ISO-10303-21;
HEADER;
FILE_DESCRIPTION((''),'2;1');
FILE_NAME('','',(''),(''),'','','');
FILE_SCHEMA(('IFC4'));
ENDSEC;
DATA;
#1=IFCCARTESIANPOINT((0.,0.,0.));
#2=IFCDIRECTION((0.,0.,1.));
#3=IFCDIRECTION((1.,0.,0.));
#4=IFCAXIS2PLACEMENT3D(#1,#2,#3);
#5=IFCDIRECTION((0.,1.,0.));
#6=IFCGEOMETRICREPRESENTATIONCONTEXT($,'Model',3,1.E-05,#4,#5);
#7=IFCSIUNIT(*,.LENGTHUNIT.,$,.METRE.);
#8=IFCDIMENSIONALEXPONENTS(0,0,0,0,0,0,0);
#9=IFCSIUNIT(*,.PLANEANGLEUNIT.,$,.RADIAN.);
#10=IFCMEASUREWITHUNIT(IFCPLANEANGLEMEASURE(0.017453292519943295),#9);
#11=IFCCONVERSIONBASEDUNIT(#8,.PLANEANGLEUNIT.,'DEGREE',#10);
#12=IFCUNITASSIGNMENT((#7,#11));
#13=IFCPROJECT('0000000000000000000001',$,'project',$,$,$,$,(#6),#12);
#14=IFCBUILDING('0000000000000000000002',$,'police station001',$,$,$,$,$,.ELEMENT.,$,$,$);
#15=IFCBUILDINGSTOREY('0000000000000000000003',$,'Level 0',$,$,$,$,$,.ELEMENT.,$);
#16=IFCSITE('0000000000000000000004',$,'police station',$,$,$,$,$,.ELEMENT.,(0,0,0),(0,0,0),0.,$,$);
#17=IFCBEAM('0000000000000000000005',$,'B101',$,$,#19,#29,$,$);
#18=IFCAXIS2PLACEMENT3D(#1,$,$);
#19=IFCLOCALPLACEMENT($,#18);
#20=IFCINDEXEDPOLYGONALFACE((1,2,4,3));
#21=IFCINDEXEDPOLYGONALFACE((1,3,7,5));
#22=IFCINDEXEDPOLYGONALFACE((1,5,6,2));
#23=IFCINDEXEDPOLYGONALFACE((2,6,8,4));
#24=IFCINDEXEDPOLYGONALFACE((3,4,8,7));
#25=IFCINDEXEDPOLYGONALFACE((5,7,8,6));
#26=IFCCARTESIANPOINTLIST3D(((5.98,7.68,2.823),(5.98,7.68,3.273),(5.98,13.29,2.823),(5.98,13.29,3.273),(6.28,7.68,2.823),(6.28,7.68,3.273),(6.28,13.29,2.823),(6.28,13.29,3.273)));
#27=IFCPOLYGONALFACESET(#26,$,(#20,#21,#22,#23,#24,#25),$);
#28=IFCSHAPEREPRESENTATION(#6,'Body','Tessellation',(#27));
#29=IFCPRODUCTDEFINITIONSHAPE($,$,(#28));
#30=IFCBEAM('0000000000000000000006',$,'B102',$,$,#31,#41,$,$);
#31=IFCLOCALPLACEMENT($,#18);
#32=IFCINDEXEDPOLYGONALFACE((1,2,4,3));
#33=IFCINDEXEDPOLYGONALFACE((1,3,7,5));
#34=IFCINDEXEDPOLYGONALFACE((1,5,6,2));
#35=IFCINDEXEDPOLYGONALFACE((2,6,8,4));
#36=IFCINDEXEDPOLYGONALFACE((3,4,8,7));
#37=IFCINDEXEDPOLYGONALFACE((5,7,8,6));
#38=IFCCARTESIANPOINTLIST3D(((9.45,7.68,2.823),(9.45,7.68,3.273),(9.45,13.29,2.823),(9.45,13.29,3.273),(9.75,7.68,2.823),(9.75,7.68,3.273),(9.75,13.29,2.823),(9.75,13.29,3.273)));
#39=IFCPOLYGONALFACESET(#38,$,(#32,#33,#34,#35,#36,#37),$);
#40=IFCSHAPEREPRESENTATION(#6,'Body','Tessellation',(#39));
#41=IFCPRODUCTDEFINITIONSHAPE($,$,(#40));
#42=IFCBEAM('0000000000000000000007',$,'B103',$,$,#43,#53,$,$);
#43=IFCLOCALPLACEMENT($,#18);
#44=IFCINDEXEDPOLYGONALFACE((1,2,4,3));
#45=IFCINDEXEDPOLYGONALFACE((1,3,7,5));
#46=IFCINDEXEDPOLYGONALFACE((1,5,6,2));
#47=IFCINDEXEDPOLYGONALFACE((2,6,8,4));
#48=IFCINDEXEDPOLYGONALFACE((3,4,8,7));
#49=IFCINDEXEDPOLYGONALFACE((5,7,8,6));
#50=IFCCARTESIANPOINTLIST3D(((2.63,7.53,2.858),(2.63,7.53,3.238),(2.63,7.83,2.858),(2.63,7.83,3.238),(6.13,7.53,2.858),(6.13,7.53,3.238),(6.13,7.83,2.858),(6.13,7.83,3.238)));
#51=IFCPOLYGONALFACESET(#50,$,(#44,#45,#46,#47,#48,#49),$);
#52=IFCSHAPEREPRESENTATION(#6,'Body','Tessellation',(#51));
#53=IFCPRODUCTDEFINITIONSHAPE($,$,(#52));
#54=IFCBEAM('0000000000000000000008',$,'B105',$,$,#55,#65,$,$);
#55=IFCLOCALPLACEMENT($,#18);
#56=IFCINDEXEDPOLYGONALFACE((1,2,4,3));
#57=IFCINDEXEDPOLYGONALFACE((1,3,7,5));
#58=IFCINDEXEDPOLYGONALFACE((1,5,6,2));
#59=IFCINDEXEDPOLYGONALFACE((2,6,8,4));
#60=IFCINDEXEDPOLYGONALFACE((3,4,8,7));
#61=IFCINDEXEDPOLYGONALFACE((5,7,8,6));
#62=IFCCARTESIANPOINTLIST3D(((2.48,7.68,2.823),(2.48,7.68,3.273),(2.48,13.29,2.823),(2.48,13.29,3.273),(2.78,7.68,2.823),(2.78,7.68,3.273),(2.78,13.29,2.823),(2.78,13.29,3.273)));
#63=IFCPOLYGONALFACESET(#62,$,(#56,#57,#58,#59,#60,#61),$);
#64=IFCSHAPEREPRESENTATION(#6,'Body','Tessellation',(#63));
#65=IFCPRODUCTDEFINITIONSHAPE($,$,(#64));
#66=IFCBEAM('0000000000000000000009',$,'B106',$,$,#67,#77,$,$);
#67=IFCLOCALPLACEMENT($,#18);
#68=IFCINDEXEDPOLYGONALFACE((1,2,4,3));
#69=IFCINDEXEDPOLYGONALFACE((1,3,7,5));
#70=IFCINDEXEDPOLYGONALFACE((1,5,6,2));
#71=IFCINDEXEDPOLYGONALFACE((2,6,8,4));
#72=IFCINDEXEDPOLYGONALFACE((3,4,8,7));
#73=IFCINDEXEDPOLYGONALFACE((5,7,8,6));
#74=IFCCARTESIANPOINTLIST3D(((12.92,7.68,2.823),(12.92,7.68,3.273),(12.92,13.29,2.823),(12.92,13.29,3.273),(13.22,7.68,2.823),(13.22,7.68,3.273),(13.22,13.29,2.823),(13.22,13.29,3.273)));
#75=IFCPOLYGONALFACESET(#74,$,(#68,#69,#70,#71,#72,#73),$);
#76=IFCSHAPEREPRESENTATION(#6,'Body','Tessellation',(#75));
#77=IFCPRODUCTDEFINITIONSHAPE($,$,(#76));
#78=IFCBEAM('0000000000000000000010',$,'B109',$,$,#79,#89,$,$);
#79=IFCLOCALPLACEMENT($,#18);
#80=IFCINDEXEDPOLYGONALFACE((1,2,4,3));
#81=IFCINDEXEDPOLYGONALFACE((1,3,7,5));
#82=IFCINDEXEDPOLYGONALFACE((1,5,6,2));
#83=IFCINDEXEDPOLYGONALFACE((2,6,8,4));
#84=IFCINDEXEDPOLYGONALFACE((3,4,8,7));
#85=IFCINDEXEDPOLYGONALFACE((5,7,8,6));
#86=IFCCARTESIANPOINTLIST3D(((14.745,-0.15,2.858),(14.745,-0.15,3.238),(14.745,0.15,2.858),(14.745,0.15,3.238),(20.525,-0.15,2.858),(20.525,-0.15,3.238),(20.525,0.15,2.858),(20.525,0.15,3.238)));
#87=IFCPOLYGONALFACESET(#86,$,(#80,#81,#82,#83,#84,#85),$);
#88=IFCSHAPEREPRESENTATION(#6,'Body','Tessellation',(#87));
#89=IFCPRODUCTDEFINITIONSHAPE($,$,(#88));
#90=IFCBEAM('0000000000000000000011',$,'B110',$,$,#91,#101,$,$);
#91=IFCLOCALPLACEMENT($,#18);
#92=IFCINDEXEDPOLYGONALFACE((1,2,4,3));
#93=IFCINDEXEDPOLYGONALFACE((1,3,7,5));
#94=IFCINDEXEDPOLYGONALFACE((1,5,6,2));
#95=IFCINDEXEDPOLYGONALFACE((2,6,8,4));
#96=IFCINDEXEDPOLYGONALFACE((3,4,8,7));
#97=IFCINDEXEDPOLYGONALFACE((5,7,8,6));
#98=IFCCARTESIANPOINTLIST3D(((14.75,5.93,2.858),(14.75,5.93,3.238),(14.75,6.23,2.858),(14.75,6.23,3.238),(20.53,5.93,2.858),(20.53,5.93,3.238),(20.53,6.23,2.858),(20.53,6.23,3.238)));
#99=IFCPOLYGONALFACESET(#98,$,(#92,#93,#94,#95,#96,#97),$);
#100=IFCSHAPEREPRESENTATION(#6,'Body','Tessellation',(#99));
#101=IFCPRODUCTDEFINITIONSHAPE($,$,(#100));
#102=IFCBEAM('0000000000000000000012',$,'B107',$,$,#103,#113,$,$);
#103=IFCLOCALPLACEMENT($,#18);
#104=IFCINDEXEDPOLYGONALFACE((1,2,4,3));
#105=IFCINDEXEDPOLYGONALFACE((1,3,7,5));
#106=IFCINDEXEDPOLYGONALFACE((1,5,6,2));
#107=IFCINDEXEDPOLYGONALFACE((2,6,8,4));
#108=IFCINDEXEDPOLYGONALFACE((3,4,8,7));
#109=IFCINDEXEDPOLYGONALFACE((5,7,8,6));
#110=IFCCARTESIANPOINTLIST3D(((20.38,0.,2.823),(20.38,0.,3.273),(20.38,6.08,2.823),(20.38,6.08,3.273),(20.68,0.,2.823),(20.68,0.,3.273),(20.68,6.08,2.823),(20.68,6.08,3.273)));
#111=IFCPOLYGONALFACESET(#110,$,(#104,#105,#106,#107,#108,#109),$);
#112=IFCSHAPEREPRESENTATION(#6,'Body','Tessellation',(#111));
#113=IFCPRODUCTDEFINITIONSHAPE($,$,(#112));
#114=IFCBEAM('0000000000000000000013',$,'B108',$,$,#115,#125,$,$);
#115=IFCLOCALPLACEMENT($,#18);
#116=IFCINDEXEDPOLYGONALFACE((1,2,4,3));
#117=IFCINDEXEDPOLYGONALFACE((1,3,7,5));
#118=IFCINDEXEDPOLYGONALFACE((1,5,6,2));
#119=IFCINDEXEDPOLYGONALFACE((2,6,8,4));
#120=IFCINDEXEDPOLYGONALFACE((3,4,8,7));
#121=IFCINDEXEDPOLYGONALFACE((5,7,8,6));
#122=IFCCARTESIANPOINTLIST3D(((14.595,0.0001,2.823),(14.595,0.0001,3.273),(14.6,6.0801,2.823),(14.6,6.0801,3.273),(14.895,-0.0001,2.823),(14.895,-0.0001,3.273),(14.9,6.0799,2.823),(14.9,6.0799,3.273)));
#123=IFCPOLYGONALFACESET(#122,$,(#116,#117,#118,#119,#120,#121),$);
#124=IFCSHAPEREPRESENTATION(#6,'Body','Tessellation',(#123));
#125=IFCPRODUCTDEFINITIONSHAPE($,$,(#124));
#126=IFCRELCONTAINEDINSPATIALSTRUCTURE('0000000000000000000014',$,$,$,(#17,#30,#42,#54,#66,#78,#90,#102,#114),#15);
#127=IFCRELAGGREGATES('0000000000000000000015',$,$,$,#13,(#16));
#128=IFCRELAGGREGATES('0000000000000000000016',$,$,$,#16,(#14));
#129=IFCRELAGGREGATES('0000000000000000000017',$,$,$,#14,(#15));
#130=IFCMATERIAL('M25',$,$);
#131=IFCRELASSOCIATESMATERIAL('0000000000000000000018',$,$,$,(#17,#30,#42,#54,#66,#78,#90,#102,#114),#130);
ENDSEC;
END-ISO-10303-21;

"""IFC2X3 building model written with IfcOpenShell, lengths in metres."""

from ifc_helpers import new_model, entity, si_unit, converted_unit, direction, frame, frame_2d, origin_with_axes, place, context, project, spatial, rectangle, extrude, material, element, save


model = new_model("IFC2X3")

# Units and contexts
model_context = context("Model", 3, precision=1e-05, world=origin_with_axes(), true_north=direction((0.0, 1.0, 0.0)))
ifc_project = project(units=[si_unit("LENGTHUNIT", "METRE"), converted_unit("PLANEANGLEUNIT", "DEGREE", entity("IfcPlaneAngleMeasure", 0.017453292519943295), si_unit("PLANEANGLEUNIT", "RADIAN"), dimensions=[0, 0, 0, 0, 0, 0, 0])], contexts=[model_context])

# Site, building, storey
site = spatial("IfcSite", under=ifc_project, Name="police station", CompositionType="ELEMENT", RefLatitude=(0, 0, 0), RefLongitude=(0, 0, 0), RefElevation=0.0)
building = spatial("IfcBuilding", under=site, Name="police station001", CompositionType="ELEMENT")
storey = spatial("IfcBuildingStorey", under=building, Name="Level 0", CompositionType="ELEMENT")

# Shared definitions
ifc_material = material(Name="M25")
placement = place(None, origin_with_axes())

# Beams
element("IfcBeam", 1, at=placement, inside=storey, material=ifc_material, Name="B101", context=model_context, shape_type="SweptSolid", body=[
    extrude(rectangle(XDim=0.3, YDim=0.45, at=frame_2d((0.0, 0.0), x_axis=(0.0, 1.0, 0.0))), frame((6.13, 7.68, 3.048), z_axis=(0.0, 1.0, 0.0), x_axis=(0.0, 0.0, -1.0)), (0.0, 0.0, 1.0), 5.61),
])
element("IfcBeam", 2, at=placement, inside=storey, material=ifc_material, Name="B102", context=model_context, shape_type="SweptSolid", body=[
    extrude(rectangle(XDim=0.3, YDim=0.45, at=frame_2d((0.0, 0.0), x_axis=(0.0, 1.0, 0.0))), frame((9.6, 7.68, 3.048), z_axis=(0.0, 1.0, 0.0), x_axis=(0.0, 0.0, -1.0)), (0.0, 0.0, 1.0), 5.61),
])
element("IfcBeam", 3, at=placement, inside=storey, material=ifc_material, Name="B103", context=model_context, shape_type="SweptSolid", body=[
    extrude(rectangle(XDim=0.3, YDim=0.38, at=frame_2d((0.0, 0.0), x_axis=(0.0, 1.0, 0.0))), frame((2.63, 7.68, 3.048), z_axis=(1.0, 0.0, 0.0), x_axis=(0.0, 0.0, -1.0)), (0.0, 0.0, 1.0), 3.5),
])
element("IfcBeam", 4, at=placement, inside=storey, material=ifc_material, Name="B105", context=model_context, shape_type="SweptSolid", body=[
    extrude(rectangle(XDim=0.3, YDim=0.45, at=frame_2d((0.0, 0.0), x_axis=(0.0, 1.0, 0.0))), frame((2.63, 13.29, 3.048), z_axis=(0.0, -1.0, 0.0), x_axis=(0.0, 0.0, -1.0)), (0.0, 0.0, 1.0), 5.61),
])
element("IfcBeam", 5, at=placement, inside=storey, material=ifc_material, Name="B106", context=model_context, shape_type="SweptSolid", body=[
    extrude(rectangle(XDim=0.3, YDim=0.45, at=frame_2d((0.0, 0.0), x_axis=(0.0, 1.0, 0.0))), frame((13.07, 13.29, 3.048), z_axis=(0.0, -1.0, 0.0), x_axis=(0.0, 0.0, -1.0)), (0.0, 0.0, 1.0), 5.61),
])
element("IfcBeam", 6, at=placement, inside=storey, material=ifc_material, Name="B109", context=model_context, shape_type="SweptSolid", body=[
    extrude(rectangle(XDim=0.3, YDim=0.38, at=frame_2d((0.0, 0.0), x_axis=(0.0, 1.0, 0.0))), frame((14.745, 0.0, 3.048), z_axis=(1.0, 0.0, 0.0), x_axis=(0.0, 0.0, -1.0)), (0.0, 0.0, 1.0), 5.78),
])
element("IfcBeam", 7, at=placement, inside=storey, material=ifc_material, Name="B110", context=model_context, shape_type="SweptSolid", body=[
    extrude(rectangle(XDim=0.3, YDim=0.38, at=frame_2d((0.0, 0.0), x_axis=(0.0, 1.0, 0.0))), frame((20.53, 6.08, 3.048), z_axis=(-1.0, 0.0, 0.0), x_axis=(0.0, 0.0, -1.0)), (0.0, 0.0, 1.0), 5.78),
])
element("IfcBeam", 8, at=placement, inside=storey, material=ifc_material, Name="B107", context=model_context, shape_type="SweptSolid", body=[
    extrude(rectangle(XDim=0.3, YDim=0.45, at=frame_2d((0.0, 0.0), x_axis=(0.0, 1.0, 0.0))), frame((20.53, 0.0, 3.048), z_axis=(0.0, 1.0, 0.0), x_axis=(0.0, 0.0, -1.0)), (0.0, 0.0, 1.0), 6.08),
])
element("IfcBeam", 9, at=placement, inside=storey, material=ifc_material, Name="B108", context=model_context, shape_type="SweptSolid", body=[
    extrude(rectangle(XDim=0.3, YDim=0.45, at=frame_2d((0.0, 0.0), x_axis=(0.0, 1.0, 0.0))), frame((14.745, 0.0, 3.048), z_axis=(0.000822, 1.0, 0.0), x_axis=(0.0, 0.0, -1.0)), (0.0, 0.0, 1.0), 6.08),
])

save(model, "model.ifc")
